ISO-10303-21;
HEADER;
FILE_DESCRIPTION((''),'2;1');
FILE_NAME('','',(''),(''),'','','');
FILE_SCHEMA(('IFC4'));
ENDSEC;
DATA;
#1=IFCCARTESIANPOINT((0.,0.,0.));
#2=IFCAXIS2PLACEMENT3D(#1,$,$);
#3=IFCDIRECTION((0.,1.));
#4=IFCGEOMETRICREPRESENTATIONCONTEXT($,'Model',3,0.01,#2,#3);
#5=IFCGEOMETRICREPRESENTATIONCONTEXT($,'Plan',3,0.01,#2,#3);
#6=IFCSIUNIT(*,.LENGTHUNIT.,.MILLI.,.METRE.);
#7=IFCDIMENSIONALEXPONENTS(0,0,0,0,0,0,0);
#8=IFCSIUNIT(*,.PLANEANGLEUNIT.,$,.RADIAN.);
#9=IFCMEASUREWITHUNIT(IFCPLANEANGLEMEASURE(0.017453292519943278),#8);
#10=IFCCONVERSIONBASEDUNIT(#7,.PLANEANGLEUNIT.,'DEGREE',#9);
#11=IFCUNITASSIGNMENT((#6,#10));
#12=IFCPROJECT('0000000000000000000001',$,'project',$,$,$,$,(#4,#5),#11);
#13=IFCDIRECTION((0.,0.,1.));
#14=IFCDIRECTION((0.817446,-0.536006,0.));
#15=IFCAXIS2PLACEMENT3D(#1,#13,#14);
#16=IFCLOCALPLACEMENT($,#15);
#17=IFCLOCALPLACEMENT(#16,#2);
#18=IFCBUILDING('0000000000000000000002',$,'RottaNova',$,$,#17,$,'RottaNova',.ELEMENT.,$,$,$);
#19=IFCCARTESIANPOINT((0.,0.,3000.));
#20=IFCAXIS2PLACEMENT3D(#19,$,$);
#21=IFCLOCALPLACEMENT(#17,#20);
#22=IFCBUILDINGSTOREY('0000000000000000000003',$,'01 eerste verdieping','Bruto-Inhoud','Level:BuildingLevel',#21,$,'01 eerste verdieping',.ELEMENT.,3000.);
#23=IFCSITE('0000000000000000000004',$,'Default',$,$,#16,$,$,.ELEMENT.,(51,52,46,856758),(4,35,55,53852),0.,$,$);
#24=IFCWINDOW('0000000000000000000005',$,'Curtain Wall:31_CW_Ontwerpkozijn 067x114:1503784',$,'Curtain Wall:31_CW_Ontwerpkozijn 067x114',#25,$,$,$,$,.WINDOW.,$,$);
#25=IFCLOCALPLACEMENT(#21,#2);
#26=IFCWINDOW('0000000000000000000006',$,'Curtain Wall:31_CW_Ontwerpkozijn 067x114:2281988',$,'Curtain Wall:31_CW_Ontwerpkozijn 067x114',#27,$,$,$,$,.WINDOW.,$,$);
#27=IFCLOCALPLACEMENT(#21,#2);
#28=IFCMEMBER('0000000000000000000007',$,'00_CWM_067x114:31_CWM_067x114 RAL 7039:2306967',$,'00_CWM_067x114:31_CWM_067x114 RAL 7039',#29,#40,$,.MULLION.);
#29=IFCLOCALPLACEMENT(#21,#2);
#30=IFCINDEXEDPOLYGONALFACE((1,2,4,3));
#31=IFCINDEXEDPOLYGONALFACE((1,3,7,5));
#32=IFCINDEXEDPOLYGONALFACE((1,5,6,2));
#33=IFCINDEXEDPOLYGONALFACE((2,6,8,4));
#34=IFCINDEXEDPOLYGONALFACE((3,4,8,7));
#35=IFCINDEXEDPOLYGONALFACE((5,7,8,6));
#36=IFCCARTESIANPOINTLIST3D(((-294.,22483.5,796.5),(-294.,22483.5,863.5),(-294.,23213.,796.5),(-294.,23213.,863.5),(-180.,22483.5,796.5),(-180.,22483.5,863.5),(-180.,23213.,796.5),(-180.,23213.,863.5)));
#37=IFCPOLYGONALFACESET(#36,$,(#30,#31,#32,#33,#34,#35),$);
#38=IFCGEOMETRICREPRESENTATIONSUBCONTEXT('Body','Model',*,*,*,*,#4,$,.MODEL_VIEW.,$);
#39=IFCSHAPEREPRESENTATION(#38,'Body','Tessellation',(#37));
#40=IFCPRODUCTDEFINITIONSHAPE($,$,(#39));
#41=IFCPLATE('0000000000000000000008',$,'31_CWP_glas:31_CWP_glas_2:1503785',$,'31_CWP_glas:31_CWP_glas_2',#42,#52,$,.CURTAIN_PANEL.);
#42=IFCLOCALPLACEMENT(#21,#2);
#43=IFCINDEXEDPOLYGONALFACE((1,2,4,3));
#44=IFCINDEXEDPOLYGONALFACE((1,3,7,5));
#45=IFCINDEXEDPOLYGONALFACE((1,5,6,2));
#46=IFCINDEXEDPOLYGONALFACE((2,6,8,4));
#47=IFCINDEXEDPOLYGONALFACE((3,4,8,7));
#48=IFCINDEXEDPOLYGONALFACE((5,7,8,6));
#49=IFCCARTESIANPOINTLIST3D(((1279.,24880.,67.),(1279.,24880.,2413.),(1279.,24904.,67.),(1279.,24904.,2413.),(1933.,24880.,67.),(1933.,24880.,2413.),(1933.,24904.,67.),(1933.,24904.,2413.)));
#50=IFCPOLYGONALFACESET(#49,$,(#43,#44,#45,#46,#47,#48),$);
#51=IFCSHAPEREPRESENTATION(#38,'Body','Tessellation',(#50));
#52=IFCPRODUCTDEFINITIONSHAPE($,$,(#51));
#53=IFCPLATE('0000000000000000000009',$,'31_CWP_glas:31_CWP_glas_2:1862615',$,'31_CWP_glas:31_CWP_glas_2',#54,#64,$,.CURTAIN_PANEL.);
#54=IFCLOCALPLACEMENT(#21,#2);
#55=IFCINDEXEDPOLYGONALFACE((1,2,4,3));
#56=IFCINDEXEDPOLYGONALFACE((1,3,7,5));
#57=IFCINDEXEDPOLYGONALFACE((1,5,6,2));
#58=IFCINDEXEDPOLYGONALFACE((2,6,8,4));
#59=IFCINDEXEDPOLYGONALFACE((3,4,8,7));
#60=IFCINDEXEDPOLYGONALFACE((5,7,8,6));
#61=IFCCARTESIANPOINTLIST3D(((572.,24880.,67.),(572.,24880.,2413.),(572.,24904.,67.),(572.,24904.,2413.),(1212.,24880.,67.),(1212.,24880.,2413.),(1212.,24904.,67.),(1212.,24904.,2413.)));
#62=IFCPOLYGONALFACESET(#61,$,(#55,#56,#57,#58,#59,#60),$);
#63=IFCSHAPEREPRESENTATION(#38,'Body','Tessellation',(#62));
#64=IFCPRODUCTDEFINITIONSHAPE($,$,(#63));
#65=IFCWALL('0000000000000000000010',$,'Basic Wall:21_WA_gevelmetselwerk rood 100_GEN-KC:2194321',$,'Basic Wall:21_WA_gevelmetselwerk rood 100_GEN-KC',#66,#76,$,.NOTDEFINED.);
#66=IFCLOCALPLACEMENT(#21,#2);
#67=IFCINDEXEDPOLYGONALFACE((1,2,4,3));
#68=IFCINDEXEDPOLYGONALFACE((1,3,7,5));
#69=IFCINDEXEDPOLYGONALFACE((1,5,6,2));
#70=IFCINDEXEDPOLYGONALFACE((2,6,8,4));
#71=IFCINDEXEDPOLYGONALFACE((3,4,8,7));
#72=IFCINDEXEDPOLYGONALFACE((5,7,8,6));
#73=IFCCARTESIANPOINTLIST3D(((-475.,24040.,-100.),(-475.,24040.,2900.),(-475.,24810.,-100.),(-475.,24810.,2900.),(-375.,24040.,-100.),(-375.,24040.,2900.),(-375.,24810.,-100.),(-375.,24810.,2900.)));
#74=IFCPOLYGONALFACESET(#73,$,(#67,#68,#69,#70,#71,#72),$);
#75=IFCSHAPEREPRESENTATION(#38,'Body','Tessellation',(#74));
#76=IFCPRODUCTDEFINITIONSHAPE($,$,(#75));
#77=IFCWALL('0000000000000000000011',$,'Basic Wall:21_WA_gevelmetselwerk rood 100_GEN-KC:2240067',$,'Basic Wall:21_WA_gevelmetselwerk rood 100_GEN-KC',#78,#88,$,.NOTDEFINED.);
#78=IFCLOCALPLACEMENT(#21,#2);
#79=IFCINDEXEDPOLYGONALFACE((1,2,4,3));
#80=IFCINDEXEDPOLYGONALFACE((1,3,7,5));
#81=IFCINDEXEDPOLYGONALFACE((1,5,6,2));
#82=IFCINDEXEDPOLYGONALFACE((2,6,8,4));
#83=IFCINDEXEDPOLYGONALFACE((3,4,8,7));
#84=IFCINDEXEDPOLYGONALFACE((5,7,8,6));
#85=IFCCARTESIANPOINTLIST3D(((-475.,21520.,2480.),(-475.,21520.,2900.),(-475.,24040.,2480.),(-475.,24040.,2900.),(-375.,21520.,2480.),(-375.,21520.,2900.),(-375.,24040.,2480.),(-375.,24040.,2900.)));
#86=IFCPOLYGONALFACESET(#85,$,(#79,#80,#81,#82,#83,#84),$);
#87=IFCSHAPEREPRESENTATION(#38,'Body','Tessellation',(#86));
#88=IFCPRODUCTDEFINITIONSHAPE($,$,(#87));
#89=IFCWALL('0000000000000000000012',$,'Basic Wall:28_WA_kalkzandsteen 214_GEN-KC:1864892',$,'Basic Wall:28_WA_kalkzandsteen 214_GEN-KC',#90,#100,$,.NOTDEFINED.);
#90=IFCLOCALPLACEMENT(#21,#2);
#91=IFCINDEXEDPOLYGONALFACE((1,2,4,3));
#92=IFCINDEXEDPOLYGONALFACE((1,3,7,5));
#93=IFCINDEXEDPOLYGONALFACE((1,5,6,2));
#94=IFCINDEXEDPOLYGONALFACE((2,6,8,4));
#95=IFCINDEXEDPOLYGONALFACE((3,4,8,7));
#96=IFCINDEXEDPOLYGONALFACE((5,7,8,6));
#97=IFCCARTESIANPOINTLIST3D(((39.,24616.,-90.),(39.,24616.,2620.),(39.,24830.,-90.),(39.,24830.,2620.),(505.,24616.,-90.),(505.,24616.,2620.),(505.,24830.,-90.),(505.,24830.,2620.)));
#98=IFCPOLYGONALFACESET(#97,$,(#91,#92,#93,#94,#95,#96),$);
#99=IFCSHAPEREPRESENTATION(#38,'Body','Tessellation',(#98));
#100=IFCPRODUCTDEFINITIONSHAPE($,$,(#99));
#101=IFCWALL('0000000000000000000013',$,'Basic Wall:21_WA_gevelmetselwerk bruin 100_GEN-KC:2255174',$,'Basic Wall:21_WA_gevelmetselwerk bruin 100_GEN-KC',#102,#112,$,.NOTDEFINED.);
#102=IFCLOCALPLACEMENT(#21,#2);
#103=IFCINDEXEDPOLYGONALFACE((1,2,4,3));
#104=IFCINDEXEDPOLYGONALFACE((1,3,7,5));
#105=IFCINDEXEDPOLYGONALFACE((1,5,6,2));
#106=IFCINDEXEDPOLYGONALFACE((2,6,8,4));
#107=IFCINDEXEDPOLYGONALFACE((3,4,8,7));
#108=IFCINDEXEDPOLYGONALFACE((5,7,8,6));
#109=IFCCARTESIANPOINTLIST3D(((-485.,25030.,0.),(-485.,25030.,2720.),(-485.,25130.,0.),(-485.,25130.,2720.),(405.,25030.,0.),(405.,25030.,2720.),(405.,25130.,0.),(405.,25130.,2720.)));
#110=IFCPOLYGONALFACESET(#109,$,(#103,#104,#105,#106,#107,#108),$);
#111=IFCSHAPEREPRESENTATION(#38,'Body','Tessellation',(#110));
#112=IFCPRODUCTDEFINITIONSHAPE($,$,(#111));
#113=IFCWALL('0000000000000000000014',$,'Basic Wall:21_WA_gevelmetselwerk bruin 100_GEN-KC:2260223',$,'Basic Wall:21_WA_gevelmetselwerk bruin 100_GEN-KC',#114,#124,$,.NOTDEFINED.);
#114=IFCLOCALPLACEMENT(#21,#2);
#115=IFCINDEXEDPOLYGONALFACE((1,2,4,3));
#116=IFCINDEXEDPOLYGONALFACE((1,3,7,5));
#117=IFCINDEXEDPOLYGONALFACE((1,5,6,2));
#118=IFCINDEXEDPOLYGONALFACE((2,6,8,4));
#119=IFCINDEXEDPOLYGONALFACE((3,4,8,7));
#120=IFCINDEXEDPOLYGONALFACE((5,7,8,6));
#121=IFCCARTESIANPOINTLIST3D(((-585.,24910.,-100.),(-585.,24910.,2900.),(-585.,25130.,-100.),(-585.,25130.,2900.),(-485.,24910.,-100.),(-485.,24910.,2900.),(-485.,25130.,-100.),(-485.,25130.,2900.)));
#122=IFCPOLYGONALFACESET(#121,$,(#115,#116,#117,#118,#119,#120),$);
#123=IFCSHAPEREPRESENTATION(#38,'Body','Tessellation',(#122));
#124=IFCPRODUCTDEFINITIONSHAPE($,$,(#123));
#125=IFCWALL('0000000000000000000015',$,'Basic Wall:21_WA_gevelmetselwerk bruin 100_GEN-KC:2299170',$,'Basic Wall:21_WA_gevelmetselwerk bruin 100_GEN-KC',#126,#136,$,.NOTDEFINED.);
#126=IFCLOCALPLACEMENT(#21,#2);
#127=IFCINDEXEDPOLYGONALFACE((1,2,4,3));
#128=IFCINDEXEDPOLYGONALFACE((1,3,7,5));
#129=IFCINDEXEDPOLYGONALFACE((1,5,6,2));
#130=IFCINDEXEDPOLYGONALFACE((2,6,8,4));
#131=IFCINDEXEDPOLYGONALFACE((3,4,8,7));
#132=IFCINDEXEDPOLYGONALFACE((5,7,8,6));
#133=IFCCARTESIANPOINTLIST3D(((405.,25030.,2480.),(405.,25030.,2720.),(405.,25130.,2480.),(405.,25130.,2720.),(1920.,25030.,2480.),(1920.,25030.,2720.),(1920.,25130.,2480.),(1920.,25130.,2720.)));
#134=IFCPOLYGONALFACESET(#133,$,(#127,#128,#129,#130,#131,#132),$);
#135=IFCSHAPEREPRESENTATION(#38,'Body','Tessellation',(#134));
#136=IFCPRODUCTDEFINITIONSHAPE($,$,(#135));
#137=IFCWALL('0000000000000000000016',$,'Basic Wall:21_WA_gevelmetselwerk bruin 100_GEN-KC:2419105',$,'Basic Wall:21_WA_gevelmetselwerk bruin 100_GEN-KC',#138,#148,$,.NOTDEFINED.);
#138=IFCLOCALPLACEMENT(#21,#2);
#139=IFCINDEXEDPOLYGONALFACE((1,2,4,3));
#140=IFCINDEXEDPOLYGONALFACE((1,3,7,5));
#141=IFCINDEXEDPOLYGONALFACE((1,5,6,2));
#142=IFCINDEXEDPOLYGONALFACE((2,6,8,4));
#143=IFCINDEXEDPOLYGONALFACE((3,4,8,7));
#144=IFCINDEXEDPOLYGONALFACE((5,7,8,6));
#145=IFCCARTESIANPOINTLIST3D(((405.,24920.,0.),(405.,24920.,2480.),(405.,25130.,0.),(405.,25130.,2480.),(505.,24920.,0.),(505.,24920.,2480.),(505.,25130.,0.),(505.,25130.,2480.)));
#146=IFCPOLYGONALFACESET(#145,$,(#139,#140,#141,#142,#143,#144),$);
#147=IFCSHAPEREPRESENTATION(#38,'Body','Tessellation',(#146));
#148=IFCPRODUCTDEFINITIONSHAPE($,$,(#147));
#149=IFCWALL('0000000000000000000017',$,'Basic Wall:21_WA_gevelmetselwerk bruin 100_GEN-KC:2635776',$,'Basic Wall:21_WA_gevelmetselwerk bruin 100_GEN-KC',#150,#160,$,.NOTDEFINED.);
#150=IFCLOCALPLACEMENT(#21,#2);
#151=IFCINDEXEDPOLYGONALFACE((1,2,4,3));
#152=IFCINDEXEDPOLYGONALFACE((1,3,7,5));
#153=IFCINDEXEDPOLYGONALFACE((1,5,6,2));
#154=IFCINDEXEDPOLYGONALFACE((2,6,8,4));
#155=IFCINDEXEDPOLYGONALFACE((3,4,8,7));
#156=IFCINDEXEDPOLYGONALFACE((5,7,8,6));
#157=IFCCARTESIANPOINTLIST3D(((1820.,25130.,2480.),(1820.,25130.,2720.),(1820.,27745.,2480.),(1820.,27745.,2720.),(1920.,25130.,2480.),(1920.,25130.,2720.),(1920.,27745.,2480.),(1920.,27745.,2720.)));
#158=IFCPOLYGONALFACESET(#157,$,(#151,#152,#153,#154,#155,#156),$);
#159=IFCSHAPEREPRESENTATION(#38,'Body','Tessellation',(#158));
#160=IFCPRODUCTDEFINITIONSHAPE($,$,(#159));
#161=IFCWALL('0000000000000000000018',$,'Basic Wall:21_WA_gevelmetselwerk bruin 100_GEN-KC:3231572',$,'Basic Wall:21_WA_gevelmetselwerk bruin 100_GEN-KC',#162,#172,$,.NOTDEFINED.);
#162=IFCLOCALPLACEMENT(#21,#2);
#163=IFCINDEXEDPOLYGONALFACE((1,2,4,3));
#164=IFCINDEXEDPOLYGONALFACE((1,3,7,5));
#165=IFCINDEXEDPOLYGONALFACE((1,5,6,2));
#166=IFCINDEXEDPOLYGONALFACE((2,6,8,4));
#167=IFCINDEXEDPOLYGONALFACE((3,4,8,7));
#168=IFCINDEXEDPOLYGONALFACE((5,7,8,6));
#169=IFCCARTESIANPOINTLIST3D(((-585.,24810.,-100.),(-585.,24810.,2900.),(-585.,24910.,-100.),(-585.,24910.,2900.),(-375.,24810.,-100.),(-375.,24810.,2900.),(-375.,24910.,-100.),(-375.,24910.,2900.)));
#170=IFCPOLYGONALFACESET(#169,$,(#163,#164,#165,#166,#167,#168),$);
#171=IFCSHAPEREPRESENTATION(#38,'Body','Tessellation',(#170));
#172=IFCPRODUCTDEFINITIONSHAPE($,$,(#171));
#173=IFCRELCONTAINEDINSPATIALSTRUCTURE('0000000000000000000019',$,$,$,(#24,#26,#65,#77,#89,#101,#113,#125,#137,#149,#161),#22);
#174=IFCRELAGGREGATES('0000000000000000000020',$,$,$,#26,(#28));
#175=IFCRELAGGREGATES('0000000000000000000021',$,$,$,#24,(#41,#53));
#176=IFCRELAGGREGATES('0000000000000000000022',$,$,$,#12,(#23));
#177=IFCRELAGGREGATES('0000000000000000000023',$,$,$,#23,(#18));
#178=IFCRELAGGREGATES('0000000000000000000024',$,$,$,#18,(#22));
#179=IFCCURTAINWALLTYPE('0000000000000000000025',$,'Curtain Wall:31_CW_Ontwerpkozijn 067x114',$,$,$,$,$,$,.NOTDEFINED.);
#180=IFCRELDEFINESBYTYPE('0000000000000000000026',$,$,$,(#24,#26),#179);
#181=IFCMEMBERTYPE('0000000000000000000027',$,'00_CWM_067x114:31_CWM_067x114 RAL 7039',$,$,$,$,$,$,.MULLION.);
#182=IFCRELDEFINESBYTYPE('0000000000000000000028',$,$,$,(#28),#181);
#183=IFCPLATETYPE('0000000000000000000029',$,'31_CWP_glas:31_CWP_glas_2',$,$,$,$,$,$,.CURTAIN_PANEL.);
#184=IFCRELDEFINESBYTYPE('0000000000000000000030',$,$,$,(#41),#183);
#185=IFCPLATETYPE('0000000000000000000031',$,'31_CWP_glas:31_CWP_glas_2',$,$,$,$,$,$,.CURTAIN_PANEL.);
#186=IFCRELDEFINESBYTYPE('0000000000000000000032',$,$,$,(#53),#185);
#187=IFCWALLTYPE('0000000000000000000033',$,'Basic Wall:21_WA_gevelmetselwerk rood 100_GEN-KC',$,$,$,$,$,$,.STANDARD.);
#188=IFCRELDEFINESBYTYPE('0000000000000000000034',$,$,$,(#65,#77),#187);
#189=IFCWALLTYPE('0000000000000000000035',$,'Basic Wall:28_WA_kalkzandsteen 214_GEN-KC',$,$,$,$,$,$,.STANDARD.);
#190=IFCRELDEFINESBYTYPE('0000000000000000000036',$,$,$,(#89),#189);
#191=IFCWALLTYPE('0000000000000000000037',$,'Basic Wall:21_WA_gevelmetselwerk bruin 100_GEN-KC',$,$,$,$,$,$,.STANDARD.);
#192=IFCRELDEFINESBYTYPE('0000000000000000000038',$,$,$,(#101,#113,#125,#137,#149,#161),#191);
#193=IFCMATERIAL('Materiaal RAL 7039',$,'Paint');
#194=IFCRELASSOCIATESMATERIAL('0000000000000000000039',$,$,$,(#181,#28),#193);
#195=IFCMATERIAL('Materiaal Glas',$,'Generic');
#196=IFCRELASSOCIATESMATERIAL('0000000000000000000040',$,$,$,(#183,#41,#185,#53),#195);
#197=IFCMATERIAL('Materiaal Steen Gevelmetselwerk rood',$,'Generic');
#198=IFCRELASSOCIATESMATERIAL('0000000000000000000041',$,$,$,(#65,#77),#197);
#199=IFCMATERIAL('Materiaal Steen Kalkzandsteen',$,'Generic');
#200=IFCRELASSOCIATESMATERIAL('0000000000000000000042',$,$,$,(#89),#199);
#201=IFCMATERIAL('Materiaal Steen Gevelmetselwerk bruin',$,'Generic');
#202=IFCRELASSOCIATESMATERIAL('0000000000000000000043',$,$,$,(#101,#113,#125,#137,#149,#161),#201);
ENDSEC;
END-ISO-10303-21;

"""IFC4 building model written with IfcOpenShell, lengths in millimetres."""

from ifc_helpers import new_model, entity, si_unit, converted_unit, direction, frame, origin, place, context, subcontext, project, spatial, indexed_curve, outline, extrude, source, transform, mapped, material, type_object, type_shapes, element, aggregate, save


model = new_model("IFC4")

# Units and contexts
model_context = context("Model", 3, precision=0.01, world=origin(), true_north=direction((0.0, 1.0)))
plan_context = context("Plan", 3, precision=0.01, world=origin(), true_north=direction((0.0, 1.0)))
body_context = subcontext(model_context, "Body", "Model", "MODEL_VIEW")
ifc_project = project(units=[si_unit("LENGTHUNIT", "METRE", prefix="MILLI"), converted_unit("PLANEANGLEUNIT", "DEGREE", entity("IfcPlaneAngleMeasure", 0.017453292519943278), si_unit("PLANEANGLEUNIT", "RADIAN"), dimensions=[0, 0, 0, 0, 0, 0, 0])], contexts=[model_context, plan_context])

# Site, building, storey
site_placement = place(None, frame((0.0, 0.0, 0.0), z_axis=(0.0, 0.0, 1.0), x_axis=(0.817446, -0.536006, 0.0)))
site = spatial("IfcSite", under=ifc_project, at=site_placement, Name="Default", CompositionType="ELEMENT", RefLatitude=(51, 52, 46, 856758), RefLongitude=(4, 35, 55, 53852), RefElevation=0.0)
building_placement = place(site_placement, origin())
building = spatial("IfcBuilding", under=site, at=building_placement, Name="RottaNova", LongName="RottaNova", CompositionType="ELEMENT")
storey_placement = place(building_placement, frame((0.0, 0.0, 3000.0)))
storey = spatial("IfcBuildingStorey", under=building, at=storey_placement, Name="01 eerste verdieping", Description="Bruto-Inhoud", ObjectType="Level:BuildingLevel", LongName="01 eerste verdieping", CompositionType="ELEMENT", Elevation=3000.0)

# Windows, member
curtain_wall_type = type_object("IfcCurtainWallType", Name="Curtain Wall:31_CW_Ontwerpkozijn 067x114", PredefinedType="NOTDEFINED")
window_1_placement = place(storey_placement, frame((0.0, 0.0, -3000.0)))
window_1 = element("IfcWindow", 1, at=window_1_placement, inside=storey, type_object=curtain_wall_type, Name="Curtain Wall:31_CW_Ontwerpkozijn 067x114:1503784", ObjectType="Curtain Wall:31_CW_Ontwerpkozijn 067x114", PredefinedType="WINDOW")
ifc_material_1 = material(Name="Materiaal RAL 7039", Category="Paint")
window_2_placement = place(storey_placement, frame((0.0, 0.0, -3000.0)))
window_2 = element("IfcWindow", 2, at=window_2_placement, inside=storey, type_object=curtain_wall_type, Name="Curtain Wall:31_CW_Ontwerpkozijn 067x114:2281988", ObjectType="Curtain Wall:31_CW_Ontwerpkozijn 067x114", PredefinedType="WINDOW")
member_type_1 = type_object("IfcMemberType", Name="00_CWM_067x114:31_CWM_067x114 RAL 7039", PredefinedType="MULLION", material=ifc_material_1)
shared_shape_1 = source(origin(), body_context, "Body", "SweptSolid", [
    extrude(outline(indexed_curve([(-33.5, -57.0), (33.5, -57.0), (33.5, 57.0), (-33.5, 57.0), (-33.5, -57.0)], self_intersect=False)), frame((0.0, -57.0, -729.5), z_axis=(0.0, 0.0, 1.0), x_axis=(-1.0, 0.0, 0.0)), (0.0, 0.0, 1.0), 729.5),
])
type_shapes(member_type_1, [shared_shape_1])
member_1_placement = place(window_2_placement, frame((-180.0, 23213.0, 3830.0), z_axis=(0.0, 1.0, 0.0), x_axis=(0.0, 0.0, 1.0)))
member_1 = element("IfcMember", 3, at=member_1_placement, type_object=member_type_1, material=ifc_material_1, Name="00_CWM_067x114:31_CWM_067x114 RAL 7039:2306967", ObjectType="00_CWM_067x114:31_CWM_067x114 RAL 7039", PredefinedType="MULLION", context=body_context, shape_type="MappedRepresentation", body=[
    mapped(shared_shape_1, transform((0.0, 0.0, 0.0), scale=1.0)),
])
aggregate(window_2, [member_1])

# Plates
ifc_material_2 = material(Name="Materiaal Glas", Category="Generic")
plate_type_1 = type_object("IfcPlateType", Name="31_CWP_glas:31_CWP_glas_2", PredefinedType="CURTAIN_PANEL", material=ifc_material_2)
shared_shape_2 = source(origin(), body_context, "Body", "SweptSolid", [
    extrude(outline(indexed_curve([(-12.0, -327.0), (12.0, -327.0), (12.0, 327.0), (-12.0, 327.0), (-12.0, -327.0)], self_intersect=False)), frame((0.0, -57.0, 0.0), z_axis=(0.0, 0.0, 1.0), x_axis=(0.0, 1.0, 0.0)), (0.0, 0.0, 1.0), 2346.0),
])
type_shapes(plate_type_1, [shared_shape_2])
plate_1_placement = place(window_1_placement, frame((1606.0, 24835.0, 3067.0), z_axis=(0.0, 0.0, 1.0), x_axis=(-1.0, 0.0, 0.0)))
plate_1 = element("IfcPlate", 4, at=plate_1_placement, type_object=plate_type_1, material=ifc_material_2, Name="31_CWP_glas:31_CWP_glas_2:1503785", ObjectType="31_CWP_glas:31_CWP_glas_2", PredefinedType="CURTAIN_PANEL", context=body_context, shape_type="MappedRepresentation", body=[
    mapped(shared_shape_2, transform((0.0, 0.0, 0.0), scale=1.0)),
])
plate_type_2 = type_object("IfcPlateType", Name="31_CWP_glas:31_CWP_glas_2", PredefinedType="CURTAIN_PANEL", material=ifc_material_2)
shared_shape_3 = source(origin(), body_context, "Body", "SweptSolid", [
    extrude(outline(indexed_curve([(-12.0, -320.0), (12.0, -320.0), (12.0, 320.0), (-12.0, 320.0), (-12.0, -320.0)], self_intersect=False)), frame((0.0, -57.0, 0.0), z_axis=(0.0, 0.0, 1.0), x_axis=(0.0, 1.0, 0.0)), (0.0, 0.0, 1.0), 2346.0),
])
type_shapes(plate_type_2, [shared_shape_3])
plate_2_placement = place(window_1_placement, frame((892.0, 24835.0, 3067.0), z_axis=(0.0, 0.0, 1.0), x_axis=(-1.0, 0.0, 0.0)))
plate_2 = element("IfcPlate", 5, at=plate_2_placement, type_object=plate_type_2, material=ifc_material_2, Name="31_CWP_glas:31_CWP_glas_2:1862615", ObjectType="31_CWP_glas:31_CWP_glas_2", PredefinedType="CURTAIN_PANEL", context=body_context, shape_type="MappedRepresentation", body=[
    mapped(shared_shape_3, transform((0.0, 0.0, 0.0), scale=1.0)),
])
aggregate(window_1, [plate_1, plate_2])

# Walls
ifc_material_3 = material(Name="Materiaal Steen Gevelmetselwerk rood", Category="Generic")
wall_type_1 = type_object("IfcWallType", Name="Basic Wall:21_WA_gevelmetselwerk rood 100_GEN-KC", PredefinedType="STANDARD")
wall_1_placement = place(storey_placement, frame((-425.0, 24810.0, -100.0), z_axis=(0.0, 0.0, 1.0), x_axis=(0.0, -1.0, 0.0)))
element("IfcWall", 6, at=wall_1_placement, inside=storey, type_object=wall_type_1, material=ifc_material_3, Name="Basic Wall:21_WA_gevelmetselwerk rood 100_GEN-KC:2194321", ObjectType="Basic Wall:21_WA_gevelmetselwerk rood 100_GEN-KC", PredefinedType="NOTDEFINED", context=body_context, shape_type="SweptSolid", body=[
    extrude(outline(indexed_curve([(770.0, 50.0), (0.0, 50.0), (0.0, -50.0), (770.0, -50.0), (770.0, 50.0)], self_intersect=False)), origin(), (0.0, 0.0, 1.0), 3000.0),
])
wall_2_placement = place(storey_placement, frame((-425.0, 24040.0, 2480.0), z_axis=(0.0, 0.0, 1.0), x_axis=(0.0, -1.0, 0.0)))
element("IfcWall", 7, at=wall_2_placement, inside=storey, type_object=wall_type_1, material=ifc_material_3, Name="Basic Wall:21_WA_gevelmetselwerk rood 100_GEN-KC:2240067", ObjectType="Basic Wall:21_WA_gevelmetselwerk rood 100_GEN-KC", PredefinedType="NOTDEFINED", context=body_context, shape_type="SweptSolid", body=[
    extrude(outline(indexed_curve([(2520.0, 50.0), (0.0, 50.0), (0.0, -50.0), (2520.0, -50.0), (2520.0, 50.0)], self_intersect=False)), origin(), (0.0, 0.0, 1.0), 420.0),
])
ifc_material_4 = material(Name="Materiaal Steen Kalkzandsteen", Category="Generic")
wall_type_2 = type_object("IfcWallType", Name="Basic Wall:28_WA_kalkzandsteen 214_GEN-KC", PredefinedType="STANDARD")
wall_3_placement = place(storey_placement, frame((39.0, 24723.0, -90.0)))
element("IfcWall", 8, at=wall_3_placement, inside=storey, type_object=wall_type_2, material=ifc_material_4, Name="Basic Wall:28_WA_kalkzandsteen 214_GEN-KC:1864892", ObjectType="Basic Wall:28_WA_kalkzandsteen 214_GEN-KC", PredefinedType="NOTDEFINED", context=body_context, shape_type="SweptSolid", body=[
    extrude(outline(indexed_curve([(466.0, 107.0), (0.0, 107.0), (0.0, -107.0), (466.0, -107.0), (466.0, 107.0)], self_intersect=False)), origin(), (0.0, 0.0, 1.0), 2710.0),
])
ifc_material_5 = material(Name="Materiaal Steen Gevelmetselwerk bruin", Category="Generic")
wall_type_3 = type_object("IfcWallType", Name="Basic Wall:21_WA_gevelmetselwerk bruin 100_GEN-KC", PredefinedType="STANDARD")
wall_4_placement = place(storey_placement, frame((-485.0, 25080.0, 0.0)))
element("IfcWall", 9, at=wall_4_placement, inside=storey, type_object=wall_type_3, material=ifc_material_5, Name="Basic Wall:21_WA_gevelmetselwerk bruin 100_GEN-KC:2255174", ObjectType="Basic Wall:21_WA_gevelmetselwerk bruin 100_GEN-KC", PredefinedType="NOTDEFINED", context=body_context, shape_type="SweptSolid", body=[
    extrude(outline(indexed_curve([(890.0, 50.0), (0.0, 50.0), (0.0, -50.0), (890.0, -50.0), (890.0, 50.0)], self_intersect=False)), origin(), (0.0, 0.0, 1.0), 2720.0),
])
wall_5_placement = place(storey_placement, frame((-535.0, 25130.0, -100.0), z_axis=(0.0, 0.0, 1.0), x_axis=(0.0, -1.0, 0.0)))
element("IfcWall", 10, at=wall_5_placement, inside=storey, type_object=wall_type_3, material=ifc_material_5, Name="Basic Wall:21_WA_gevelmetselwerk bruin 100_GEN-KC:2260223", ObjectType="Basic Wall:21_WA_gevelmetselwerk bruin 100_GEN-KC", PredefinedType="NOTDEFINED", context=body_context, shape_type="SweptSolid", body=[
    extrude(outline(indexed_curve([(220.0, 50.0), (0.0, 50.0), (0.0, -50.0), (220.0, -50.0), (220.0, 50.0)], self_intersect=False)), origin(), (0.0, 0.0, 1.0), 3000.0),
])
wall_6_placement = place(storey_placement, frame((405.0, 25080.0, 2480.0)))
element("IfcWall", 11, at=wall_6_placement, inside=storey, type_object=wall_type_3, material=ifc_material_5, Name="Basic Wall:21_WA_gevelmetselwerk bruin 100_GEN-KC:2299170", ObjectType="Basic Wall:21_WA_gevelmetselwerk bruin 100_GEN-KC", PredefinedType="NOTDEFINED", context=body_context, shape_type="SweptSolid", body=[
    extrude(outline(indexed_curve([(1515.0, 50.0), (0.0, 50.0), (0.0, -50.0), (1515.0, -50.0), (1515.0, 50.0)], self_intersect=False)), origin(), (0.0, 0.0, 1.0), 240.0),
])
wall_7_placement = place(storey_placement, frame((455.0, 24920.0, 0.0), z_axis=(0.0, 0.0, 1.0), x_axis=(0.0, 1.0, 0.0)))
element("IfcWall", 12, at=wall_7_placement, inside=storey, type_object=wall_type_3, material=ifc_material_5, Name="Basic Wall:21_WA_gevelmetselwerk bruin 100_GEN-KC:2419105", ObjectType="Basic Wall:21_WA_gevelmetselwerk bruin 100_GEN-KC", PredefinedType="NOTDEFINED", context=body_context, shape_type="SweptSolid", body=[
    extrude(outline(indexed_curve([(210.0, 50.0), (0.0, 50.0), (0.0, -50.0), (210.0, -50.0), (210.0, 50.0)], self_intersect=False)), origin(), (0.0, 0.0, 1.0), 2480.0),
])
wall_8_placement = place(storey_placement, frame((1870.0, 25130.0, 2480.0), z_axis=(0.0, 0.0, 1.0), x_axis=(0.0, 1.0, 0.0)))
element("IfcWall", 13, at=wall_8_placement, inside=storey, type_object=wall_type_3, material=ifc_material_5, Name="Basic Wall:21_WA_gevelmetselwerk bruin 100_GEN-KC:2635776", ObjectType="Basic Wall:21_WA_gevelmetselwerk bruin 100_GEN-KC", PredefinedType="NOTDEFINED", context=body_context, shape_type="SweptSolid", body=[
    extrude(outline(indexed_curve([(2615.0, 50.0), (0.0, 50.0), (0.0, -50.0), (2615.0, -50.0), (2615.0, 50.0)], self_intersect=False)), origin(), (0.0, 0.0, 1.0), 240.0),
])
wall_9_placement = place(storey_placement, frame((-585.0, 24860.0, -100.0)))
element("IfcWall", 14, at=wall_9_placement, inside=storey, type_object=wall_type_3, material=ifc_material_5, Name="Basic Wall:21_WA_gevelmetselwerk bruin 100_GEN-KC:3231572", ObjectType="Basic Wall:21_WA_gevelmetselwerk bruin 100_GEN-KC", PredefinedType="NOTDEFINED", context=body_context, shape_type="SweptSolid", body=[
    extrude(outline(indexed_curve([(210.0, 50.0), (0.0, 50.0), (0.0, -50.0), (210.0, -50.0), (210.0, 50.0)], self_intersect=False)), origin(), (0.0, 0.0, 1.0), 3000.0),
])

save(model, "model.ifc")
